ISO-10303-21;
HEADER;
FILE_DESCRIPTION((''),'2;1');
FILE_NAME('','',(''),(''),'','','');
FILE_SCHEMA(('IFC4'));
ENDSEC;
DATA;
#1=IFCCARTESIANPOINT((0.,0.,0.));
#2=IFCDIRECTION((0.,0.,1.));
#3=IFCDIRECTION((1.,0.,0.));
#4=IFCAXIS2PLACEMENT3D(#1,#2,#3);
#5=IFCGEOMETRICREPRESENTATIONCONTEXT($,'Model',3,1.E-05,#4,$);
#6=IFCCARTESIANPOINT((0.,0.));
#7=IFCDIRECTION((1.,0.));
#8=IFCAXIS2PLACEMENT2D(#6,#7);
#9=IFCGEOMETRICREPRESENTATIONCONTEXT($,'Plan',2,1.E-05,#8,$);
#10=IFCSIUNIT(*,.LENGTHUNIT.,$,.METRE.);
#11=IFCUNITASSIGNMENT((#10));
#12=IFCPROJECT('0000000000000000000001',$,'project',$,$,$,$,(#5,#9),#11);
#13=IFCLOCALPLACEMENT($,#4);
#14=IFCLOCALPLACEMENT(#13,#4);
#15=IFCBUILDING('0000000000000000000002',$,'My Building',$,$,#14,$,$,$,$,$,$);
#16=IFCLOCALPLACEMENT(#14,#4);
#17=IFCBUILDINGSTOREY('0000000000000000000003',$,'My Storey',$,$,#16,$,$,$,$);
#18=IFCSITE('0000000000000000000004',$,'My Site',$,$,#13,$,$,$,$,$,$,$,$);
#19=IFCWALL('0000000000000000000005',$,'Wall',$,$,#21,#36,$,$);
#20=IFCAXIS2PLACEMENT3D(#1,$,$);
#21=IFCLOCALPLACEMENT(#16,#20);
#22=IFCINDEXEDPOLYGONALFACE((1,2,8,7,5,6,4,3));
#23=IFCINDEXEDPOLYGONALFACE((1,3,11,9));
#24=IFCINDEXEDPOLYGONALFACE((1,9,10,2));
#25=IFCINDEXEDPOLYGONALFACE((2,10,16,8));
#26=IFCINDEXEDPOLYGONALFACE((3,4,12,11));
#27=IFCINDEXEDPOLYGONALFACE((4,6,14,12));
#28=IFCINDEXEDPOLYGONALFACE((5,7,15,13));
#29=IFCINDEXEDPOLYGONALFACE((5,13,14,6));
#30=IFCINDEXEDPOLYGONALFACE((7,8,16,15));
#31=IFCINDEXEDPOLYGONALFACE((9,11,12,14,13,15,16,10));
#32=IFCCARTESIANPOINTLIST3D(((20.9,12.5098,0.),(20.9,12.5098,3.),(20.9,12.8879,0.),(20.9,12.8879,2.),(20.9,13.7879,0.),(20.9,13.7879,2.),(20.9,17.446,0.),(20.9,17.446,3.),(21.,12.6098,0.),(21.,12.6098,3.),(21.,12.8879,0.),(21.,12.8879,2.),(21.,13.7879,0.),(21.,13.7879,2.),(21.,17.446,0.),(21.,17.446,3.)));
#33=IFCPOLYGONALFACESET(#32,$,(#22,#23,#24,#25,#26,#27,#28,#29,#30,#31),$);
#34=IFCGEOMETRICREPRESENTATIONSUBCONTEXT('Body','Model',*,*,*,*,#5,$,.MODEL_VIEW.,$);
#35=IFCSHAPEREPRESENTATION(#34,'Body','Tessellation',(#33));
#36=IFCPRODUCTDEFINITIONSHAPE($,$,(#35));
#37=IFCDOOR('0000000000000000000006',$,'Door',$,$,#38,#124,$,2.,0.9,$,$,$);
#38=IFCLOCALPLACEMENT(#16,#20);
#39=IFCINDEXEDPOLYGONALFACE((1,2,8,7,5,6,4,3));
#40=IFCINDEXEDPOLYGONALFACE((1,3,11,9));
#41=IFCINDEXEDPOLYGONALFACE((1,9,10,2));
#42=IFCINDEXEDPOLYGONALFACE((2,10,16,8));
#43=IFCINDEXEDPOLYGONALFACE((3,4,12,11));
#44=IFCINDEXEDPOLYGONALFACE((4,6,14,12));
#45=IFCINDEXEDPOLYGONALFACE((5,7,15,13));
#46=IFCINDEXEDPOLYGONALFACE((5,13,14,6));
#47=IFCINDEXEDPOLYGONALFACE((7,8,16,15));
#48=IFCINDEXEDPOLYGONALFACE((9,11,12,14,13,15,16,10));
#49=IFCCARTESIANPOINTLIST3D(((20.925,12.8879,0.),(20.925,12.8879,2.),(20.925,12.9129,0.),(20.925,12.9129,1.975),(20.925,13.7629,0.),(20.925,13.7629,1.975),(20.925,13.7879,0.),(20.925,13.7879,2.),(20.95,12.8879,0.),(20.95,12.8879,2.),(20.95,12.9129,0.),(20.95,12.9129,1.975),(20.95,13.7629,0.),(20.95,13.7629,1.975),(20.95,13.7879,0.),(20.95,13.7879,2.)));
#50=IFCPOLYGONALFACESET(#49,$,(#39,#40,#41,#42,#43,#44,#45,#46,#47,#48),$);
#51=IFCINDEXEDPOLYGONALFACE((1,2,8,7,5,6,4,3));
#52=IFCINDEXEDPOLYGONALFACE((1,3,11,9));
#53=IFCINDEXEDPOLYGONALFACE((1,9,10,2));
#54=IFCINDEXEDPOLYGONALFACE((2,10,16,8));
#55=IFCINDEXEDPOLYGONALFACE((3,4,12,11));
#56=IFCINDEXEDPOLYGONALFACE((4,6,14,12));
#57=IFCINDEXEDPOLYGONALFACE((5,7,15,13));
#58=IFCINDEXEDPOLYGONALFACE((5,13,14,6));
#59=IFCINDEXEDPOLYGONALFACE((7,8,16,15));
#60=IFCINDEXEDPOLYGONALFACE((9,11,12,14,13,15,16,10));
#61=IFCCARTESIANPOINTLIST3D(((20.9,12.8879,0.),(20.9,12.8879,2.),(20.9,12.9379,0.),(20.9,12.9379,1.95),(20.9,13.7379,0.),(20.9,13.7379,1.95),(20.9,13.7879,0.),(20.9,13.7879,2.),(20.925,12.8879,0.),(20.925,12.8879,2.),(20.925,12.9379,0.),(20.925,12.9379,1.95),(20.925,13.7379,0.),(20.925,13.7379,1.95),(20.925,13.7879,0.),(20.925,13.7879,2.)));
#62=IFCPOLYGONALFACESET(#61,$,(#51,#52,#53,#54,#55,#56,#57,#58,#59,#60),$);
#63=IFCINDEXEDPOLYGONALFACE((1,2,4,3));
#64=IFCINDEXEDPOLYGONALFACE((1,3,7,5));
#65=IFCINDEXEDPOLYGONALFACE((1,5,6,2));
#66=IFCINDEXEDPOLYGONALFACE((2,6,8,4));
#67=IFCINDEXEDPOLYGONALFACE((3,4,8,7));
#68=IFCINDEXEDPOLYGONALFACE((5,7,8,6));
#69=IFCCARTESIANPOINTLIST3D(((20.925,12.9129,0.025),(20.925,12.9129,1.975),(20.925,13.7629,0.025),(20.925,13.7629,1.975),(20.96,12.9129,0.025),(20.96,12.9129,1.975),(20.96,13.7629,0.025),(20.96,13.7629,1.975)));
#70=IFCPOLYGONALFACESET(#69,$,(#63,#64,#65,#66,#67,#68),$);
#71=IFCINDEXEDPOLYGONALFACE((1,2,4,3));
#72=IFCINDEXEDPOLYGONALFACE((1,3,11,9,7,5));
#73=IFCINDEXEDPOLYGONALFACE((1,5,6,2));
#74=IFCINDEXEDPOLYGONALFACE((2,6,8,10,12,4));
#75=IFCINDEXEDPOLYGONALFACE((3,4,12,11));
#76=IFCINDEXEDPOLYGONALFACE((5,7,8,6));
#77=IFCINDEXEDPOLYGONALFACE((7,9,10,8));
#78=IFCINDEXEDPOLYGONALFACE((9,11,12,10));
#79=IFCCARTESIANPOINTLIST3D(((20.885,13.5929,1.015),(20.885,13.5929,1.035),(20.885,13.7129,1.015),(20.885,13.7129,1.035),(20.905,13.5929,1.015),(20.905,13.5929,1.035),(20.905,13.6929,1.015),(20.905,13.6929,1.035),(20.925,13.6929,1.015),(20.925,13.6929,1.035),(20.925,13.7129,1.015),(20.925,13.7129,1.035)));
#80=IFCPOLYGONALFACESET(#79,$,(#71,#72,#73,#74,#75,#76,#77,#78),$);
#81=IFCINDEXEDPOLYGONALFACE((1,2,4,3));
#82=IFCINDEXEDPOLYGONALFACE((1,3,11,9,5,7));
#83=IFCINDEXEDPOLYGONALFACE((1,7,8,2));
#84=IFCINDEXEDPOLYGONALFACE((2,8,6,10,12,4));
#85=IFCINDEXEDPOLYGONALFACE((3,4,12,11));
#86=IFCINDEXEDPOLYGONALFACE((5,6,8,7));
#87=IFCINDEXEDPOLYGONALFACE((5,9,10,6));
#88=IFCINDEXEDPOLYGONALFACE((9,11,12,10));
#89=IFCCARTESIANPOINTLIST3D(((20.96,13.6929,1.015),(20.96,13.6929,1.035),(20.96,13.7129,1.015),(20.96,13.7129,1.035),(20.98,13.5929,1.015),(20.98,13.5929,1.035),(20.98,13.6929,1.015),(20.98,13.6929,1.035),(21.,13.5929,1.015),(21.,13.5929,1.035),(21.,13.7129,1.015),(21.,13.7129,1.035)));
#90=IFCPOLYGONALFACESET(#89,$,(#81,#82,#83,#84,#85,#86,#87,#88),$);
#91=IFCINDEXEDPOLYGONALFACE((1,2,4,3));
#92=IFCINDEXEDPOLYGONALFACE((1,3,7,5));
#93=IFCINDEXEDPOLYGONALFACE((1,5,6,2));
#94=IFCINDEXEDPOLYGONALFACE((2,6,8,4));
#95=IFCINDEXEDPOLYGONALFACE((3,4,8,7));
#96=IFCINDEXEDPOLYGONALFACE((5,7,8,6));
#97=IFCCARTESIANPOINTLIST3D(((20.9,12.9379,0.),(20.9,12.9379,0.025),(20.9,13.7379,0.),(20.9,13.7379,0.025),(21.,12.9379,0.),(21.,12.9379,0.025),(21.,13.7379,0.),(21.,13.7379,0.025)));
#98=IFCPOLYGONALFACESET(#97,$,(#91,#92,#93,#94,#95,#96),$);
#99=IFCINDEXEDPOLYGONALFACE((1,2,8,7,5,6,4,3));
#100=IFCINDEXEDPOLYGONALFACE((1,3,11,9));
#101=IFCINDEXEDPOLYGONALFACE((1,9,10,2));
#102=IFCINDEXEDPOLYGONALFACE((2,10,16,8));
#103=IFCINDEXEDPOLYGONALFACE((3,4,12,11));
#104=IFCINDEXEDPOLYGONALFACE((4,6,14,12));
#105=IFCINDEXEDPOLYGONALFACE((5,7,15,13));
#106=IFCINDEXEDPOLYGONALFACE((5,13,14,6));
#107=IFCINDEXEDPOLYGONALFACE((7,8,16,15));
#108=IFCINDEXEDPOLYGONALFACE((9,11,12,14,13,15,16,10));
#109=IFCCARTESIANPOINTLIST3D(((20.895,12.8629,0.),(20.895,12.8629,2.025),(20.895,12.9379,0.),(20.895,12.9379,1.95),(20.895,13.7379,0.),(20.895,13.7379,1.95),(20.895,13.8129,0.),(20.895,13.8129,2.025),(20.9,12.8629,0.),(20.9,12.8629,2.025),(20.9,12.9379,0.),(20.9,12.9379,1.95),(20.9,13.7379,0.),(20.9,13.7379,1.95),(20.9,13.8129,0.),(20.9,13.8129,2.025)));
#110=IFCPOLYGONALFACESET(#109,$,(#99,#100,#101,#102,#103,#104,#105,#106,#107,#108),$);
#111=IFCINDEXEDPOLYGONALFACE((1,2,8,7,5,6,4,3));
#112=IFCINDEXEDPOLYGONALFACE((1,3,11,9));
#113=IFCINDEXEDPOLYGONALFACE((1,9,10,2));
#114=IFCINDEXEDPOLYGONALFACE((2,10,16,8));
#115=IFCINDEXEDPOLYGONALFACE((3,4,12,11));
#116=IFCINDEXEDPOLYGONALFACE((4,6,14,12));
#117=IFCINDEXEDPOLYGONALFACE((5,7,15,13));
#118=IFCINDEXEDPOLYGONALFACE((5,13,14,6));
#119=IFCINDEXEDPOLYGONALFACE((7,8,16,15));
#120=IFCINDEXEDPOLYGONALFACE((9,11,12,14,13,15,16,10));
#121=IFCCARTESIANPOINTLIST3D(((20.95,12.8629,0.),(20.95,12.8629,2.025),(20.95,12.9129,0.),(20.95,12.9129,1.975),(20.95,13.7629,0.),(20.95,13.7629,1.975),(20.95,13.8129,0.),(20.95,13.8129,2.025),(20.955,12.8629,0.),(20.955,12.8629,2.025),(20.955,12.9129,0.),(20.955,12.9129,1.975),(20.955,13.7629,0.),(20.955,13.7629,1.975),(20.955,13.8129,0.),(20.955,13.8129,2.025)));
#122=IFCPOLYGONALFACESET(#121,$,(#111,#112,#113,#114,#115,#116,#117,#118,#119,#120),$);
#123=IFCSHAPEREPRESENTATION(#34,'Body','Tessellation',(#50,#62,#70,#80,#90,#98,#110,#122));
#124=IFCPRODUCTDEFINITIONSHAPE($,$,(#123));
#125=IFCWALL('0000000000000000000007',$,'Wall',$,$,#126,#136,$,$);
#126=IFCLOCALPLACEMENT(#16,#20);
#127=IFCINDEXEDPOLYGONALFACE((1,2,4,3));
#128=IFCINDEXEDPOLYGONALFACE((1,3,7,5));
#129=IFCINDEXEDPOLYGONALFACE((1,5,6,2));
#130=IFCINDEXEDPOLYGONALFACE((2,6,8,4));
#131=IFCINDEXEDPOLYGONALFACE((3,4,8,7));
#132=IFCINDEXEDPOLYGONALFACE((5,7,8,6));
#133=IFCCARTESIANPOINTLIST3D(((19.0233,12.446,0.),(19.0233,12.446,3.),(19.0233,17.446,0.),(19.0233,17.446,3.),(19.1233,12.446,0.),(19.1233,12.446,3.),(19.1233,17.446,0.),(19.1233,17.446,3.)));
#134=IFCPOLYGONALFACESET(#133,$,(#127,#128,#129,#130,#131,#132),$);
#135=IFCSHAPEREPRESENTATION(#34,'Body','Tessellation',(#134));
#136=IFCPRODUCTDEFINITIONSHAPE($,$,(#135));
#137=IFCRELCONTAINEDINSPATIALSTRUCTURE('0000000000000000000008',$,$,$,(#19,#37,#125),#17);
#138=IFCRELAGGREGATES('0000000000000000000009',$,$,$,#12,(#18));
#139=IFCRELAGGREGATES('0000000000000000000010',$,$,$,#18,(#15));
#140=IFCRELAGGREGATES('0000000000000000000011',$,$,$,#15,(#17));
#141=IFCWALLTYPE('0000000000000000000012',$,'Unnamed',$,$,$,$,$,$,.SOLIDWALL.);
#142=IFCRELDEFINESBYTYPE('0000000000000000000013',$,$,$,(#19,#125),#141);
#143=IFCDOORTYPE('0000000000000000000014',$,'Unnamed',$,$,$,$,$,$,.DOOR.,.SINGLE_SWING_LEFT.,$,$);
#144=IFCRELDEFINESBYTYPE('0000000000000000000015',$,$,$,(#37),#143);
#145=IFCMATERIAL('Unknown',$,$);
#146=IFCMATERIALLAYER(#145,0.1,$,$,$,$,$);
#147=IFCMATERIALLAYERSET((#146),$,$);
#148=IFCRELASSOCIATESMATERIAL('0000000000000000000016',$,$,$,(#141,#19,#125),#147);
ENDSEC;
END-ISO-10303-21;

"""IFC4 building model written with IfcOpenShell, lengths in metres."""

from ifc_helpers import new_model, entity, si_unit, frame, origin_with_axes, origin_2d_with_axis, place, context, subcontext, project, spatial, line, indexed_curve, outline, extrude, shape, source, transform, mapped, material, layer, layer_set, layer_usage, type_object, type_shapes, element, fill, save


model = new_model("IFC4")

# Units and contexts
model_context = context("Model", 3, precision=1e-05, world=origin_with_axes())
plan_context = context("Plan", 2, precision=1e-05, world=origin_2d_with_axis())
body_context_1 = subcontext(model_context, "Body", "Model", "MODEL_VIEW")
body_context_2 = subcontext(plan_context, "Body", "Plan", "PLAN_VIEW")
ifc_project = project(units=[si_unit("LENGTHUNIT", "METRE")], contexts=[model_context, plan_context])

# Site, building, storey
site_placement = place(None, origin_with_axes())
site = spatial("IfcSite", under=ifc_project, at=site_placement, Name="My Site")
building_placement = place(site_placement, origin_with_axes())
building = spatial("IfcBuilding", under=site, at=building_placement, Name="My Building")
storey_placement = place(building_placement, origin_with_axes())
storey = spatial("IfcBuildingStorey", under=building, at=storey_placement, Name="My Storey")

# Shared definitions
ifc_material = material(Name="Unknown")

# Shared definitions
ifc_layer_1 = layer(ifc_material, 0.1)
ifc_layer_set_1 = layer_set([ifc_layer_1])
wall_type = type_object("IfcWallType", Name="Unnamed", PredefinedType="SOLIDWALL", material=ifc_layer_set_1)

# Shared definitions
shared_shape_1 = source(origin_with_axes(), body_context_1, "Body", "SweptSolid", [
    extrude(outline(indexed_curve([(0.0, 0.0), (0.9, 0.0), (0.9, 2.0), (0.0, 2.0)], segments=[line(1, 2, 3, 4, 1)])), frame((0.0, -0.6, 0.0), z_axis=(0.0, -1.0, 0.0), x_axis=(1.0, 0.0, 0.0)), (0.0, 0.0, -1.0), 1.2),
])
door_type_1 = type_object("IfcDoorType", Name="Unnamed", OperationType="SINGLE_SWING_LEFT", PredefinedType="DOOR")
shared_shape_2 = source(origin_with_axes(), body_context_1, "Body", "SweptSolid", [
    extrude(outline(indexed_curve([(0.0, 0.0), (0.0, 2.0), (0.9, 2.0), (0.9, 0.0), (0.875, 0.0), (0.875, 1.975), (0.025, 1.975), (0.025, 0.0)], segments=[line(1, 2, 3, 4, 5, 6, 7, 8, 1)])), frame((0.0, 0.025, 0.0), z_axis=(0.0, -1.0, 0.0), x_axis=(1.0, 0.0, 0.0)), (0.0, 0.0, -1.0), 0.025),
    extrude(outline(indexed_curve([(0.0, 0.0), (0.0, 2.0), (0.9, 2.0), (0.9, 0.0), (0.85, 0.0), (0.85, 1.95), (0.05, 1.95), (0.05, 0.0)], segments=[line(1, 2, 3, 4, 5, 6, 7, 8, 1)])), frame((0.0, 0.0, 0.0), z_axis=(0.0, -1.0, 0.0), x_axis=(1.0, 0.0, 0.0)), (0.0, 0.0, -1.0), 0.025),
    extrude(outline(indexed_curve([(0.0, 0.0), (0.85, 0.0), (0.85, 0.035), (0.0, 0.035)], segments=[line(1, 2, 3, 4, 1)])), frame((0.025, 0.025, 0.025), z_axis=(0.0, 0.0, 1.0), x_axis=(1.0, 0.0, 0.0)), (0.0, 0.0, 1.0), 1.95),
    extrude(outline(indexed_curve([(0.0, 0.0), (0.0, -0.04), (0.12, -0.04), (0.12, -0.02), (0.02, -0.02), (0.02, 0.0)], segments=[line(1, 2, 3, 4, 5, 6, 1)])), frame((0.075, 0.025, 1.015), z_axis=(0.0, 0.0, 1.0), x_axis=(1.0, 0.0, 0.0)), (0.0, 0.0, 1.0), 0.02),
    extrude(outline(indexed_curve([(0.0, 0.0), (0.0, 0.04), (0.12, 0.04), (0.12, 0.02), (0.02, 0.02), (0.02, 0.0)], segments=[line(1, 2, 3, 4, 5, 6, 1)])), frame((0.075, 0.06, 1.015), z_axis=(0.0, 0.0, 1.0), x_axis=(1.0, 0.0, 0.0)), (0.0, 0.0, 1.0), 0.02),
    extrude(outline(indexed_curve([(0.0, 0.0), (0.8, 0.0), (0.8, 0.1), (0.0, 0.1)], segments=[line(1, 2, 3, 4, 1)])), frame((0.05, 0.0, 0.0), z_axis=(0.0, 0.0, 1.0), x_axis=(1.0, 0.0, 0.0)), (0.0, 0.0, 1.0), 0.025),
    extrude(outline(indexed_curve([(0.0, 0.0), (0.0, 2.025), (0.95, 2.025), (0.95, 0.0), (0.875, 0.0), (0.875, 1.95), (0.075, 1.95), (0.075, 0.0)], segments=[line(1, 2, 3, 4, 5, 6, 7, 8, 1)])), frame((-0.025, -0.005, 0.0), z_axis=(0.0, -1.0, 0.0), x_axis=(1.0, 0.0, 0.0)), (0.0, 0.0, -1.0), 0.005),
    extrude(outline(indexed_curve([(0.0, 0.0), (0.0, 2.025), (0.95, 2.025), (0.95, 0.0), (0.9, 0.0), (0.9, 1.975), (0.05, 1.975), (0.05, 0.0)], segments=[line(1, 2, 3, 4, 5, 6, 7, 8, 1)])), frame((-0.025, 0.05, 0.0), z_axis=(0.0, -1.0, 0.0), x_axis=(1.0, 0.0, 0.0)), (0.0, 0.0, -1.0), 0.005),
])
shared_shape_3 = source(origin_with_axes(), body_context_2, "Body", "Curve2D", [
    entity("IfcIndexedPolyCurve", entity("IfcCartesianPointList2D", [[0.0, 0.0], [0.0, 0.05], [0.025, 0.05], [0.025, 0.025], [0.05, 0.025], [0.05, 0.0]]), [entity("IfcLineIndex", [1, 2, 3, 4, 5, 6, 1])]),
    entity("IfcIndexedPolyCurve", entity("IfcCartesianPointList2D", [[0.9, 0.0], [0.9, 0.05], [0.875, 0.05], [0.875, 0.025], [0.85, 0.025], [0.85, 0.0]]), [entity("IfcLineIndex", [1, 2, 3, 4, 5, 6, 1])]),
    entity("IfcTrimmedCurve", entity("IfcEllipse", entity("IfcAxis2Placement2D", entity("IfcCartesianPoint", [0.84, 0.05]), entity("IfcDirection", [1.0, 0.0])), 0.815, 0.85), [entity("IfcCartesianPoint", [0.84, 0.9])], [entity("IfcCartesianPoint", [0.025, 0.05])], True, "CARTESIAN"),
    entity("IfcIndexedPolyCurve", entity("IfcCartesianPointList2D", [[0.875, 0.05], [0.84, 0.05], [0.84, 0.9], [0.875, 0.9]]), [entity("IfcLineIndex", [1, 2, 3, 4, 1])]),
])
type_shapes(door_type_1, [shared_shape_2, shared_shape_3])

# Wall, opening, door
ifc_layer_usage_1 = layer_usage(ifc_layer_set_1, "AXIS2", "POSITIVE", 0.0)
wall_1_placement = place(storey_placement, frame((21.0, 12.6098, 0.0), z_axis=(0.0, 0.0, 1.0), x_axis=(0.0, 1.0, 0.0)))
wall_1 = element("IfcWall", 1, at=wall_1_placement, inside=storey, type_object=wall_type, material=ifc_layer_usage_1, Name="Wall", context=body_context_1, shape_type="SweptSolid", body=[
    extrude(outline(indexed_curve([(0.0, 0.0), (-0.1, 0.1), (4.8363, 0.1), (4.8363, 0.0)], segments=[line(1, 2, 3, 4, 1)])), origin_with_axes(), (0.0, 0.0, 1.0), 3.0),
])
opening_1_placement = place(wall_1_placement, frame((1.1782, 0.1, 0.0), z_axis=(0.0, 0.0, 1.0), x_axis=(-1.0, 0.0, 0.0)))
opening_1 = element("IfcOpeningElement", 2, at=opening_1_placement, cuts=wall_1, PredefinedType="OPENING", context=body_context_1, shape_type="MappedRepresentation", body=[
    mapped(shared_shape_1, transform((0.0, 0.0, 0.0), x_axis=(1.0, 0.0, 0.0), y_axis=(0.0, 1.0, 0.0), z_axis=(0.0, 0.0, 1.0), scale=1.0)),
])
door_1_placement = place(opening_1_placement, frame((0.0, 0.0, 0.0), z_axis=(0.0, 0.0, 1.0), x_axis=(1.0, 0.0, 0.0)))
door_1 = element("IfcDoor", 3, at=door_1_placement, inside=storey, type_object=door_type_1, Name="Door", OverallHeight=2.0, OverallWidth=0.9, shapes=[
    shape(body_context_1, "Body", "MappedRepresentation", [mapped(shared_shape_2, transform((0.0, 0.0, 0.0), x_axis=(1.0, 0.0, 0.0), y_axis=(0.0, 1.0, 0.0), z_axis=(0.0, 0.0, 1.0), scale=1.0))]),
    shape(body_context_2, "Body", "MappedRepresentation", [mapped(shared_shape_3, transform((0.0, 0.0, 0.0), x_axis=(1.0, 0.0, 0.0), y_axis=(0.0, 1.0, 0.0), z_axis=(0.0, 0.0, 1.0), scale=1.0))]),
])
fill(opening_1, door_1)

# Wall
ifc_layer_usage_2 = layer_usage(ifc_layer_set_1, "AXIS2", "POSITIVE", 0.0)
wall_2_placement = place(storey_placement, frame((19.0233, 17.446, 0.0), z_axis=(0.0, 0.0, 1.0), x_axis=(0.0, -1.0, 0.0)))
element("IfcWall", 4, at=wall_2_placement, inside=storey, type_object=wall_type, material=ifc_layer_usage_2, Name="Wall", context=body_context_1, shape_type="SweptSolid", body=[
    extrude(outline(indexed_curve([(0.0, 0.0), (0.0, 0.1), (5.0, 0.1), (5.0, 0.0)], segments=[line(1, 2, 3, 4, 1)])), origin_with_axes(), (0.0, 0.0, 1.0), 3.0),
])

save(model, "model.ifc")
